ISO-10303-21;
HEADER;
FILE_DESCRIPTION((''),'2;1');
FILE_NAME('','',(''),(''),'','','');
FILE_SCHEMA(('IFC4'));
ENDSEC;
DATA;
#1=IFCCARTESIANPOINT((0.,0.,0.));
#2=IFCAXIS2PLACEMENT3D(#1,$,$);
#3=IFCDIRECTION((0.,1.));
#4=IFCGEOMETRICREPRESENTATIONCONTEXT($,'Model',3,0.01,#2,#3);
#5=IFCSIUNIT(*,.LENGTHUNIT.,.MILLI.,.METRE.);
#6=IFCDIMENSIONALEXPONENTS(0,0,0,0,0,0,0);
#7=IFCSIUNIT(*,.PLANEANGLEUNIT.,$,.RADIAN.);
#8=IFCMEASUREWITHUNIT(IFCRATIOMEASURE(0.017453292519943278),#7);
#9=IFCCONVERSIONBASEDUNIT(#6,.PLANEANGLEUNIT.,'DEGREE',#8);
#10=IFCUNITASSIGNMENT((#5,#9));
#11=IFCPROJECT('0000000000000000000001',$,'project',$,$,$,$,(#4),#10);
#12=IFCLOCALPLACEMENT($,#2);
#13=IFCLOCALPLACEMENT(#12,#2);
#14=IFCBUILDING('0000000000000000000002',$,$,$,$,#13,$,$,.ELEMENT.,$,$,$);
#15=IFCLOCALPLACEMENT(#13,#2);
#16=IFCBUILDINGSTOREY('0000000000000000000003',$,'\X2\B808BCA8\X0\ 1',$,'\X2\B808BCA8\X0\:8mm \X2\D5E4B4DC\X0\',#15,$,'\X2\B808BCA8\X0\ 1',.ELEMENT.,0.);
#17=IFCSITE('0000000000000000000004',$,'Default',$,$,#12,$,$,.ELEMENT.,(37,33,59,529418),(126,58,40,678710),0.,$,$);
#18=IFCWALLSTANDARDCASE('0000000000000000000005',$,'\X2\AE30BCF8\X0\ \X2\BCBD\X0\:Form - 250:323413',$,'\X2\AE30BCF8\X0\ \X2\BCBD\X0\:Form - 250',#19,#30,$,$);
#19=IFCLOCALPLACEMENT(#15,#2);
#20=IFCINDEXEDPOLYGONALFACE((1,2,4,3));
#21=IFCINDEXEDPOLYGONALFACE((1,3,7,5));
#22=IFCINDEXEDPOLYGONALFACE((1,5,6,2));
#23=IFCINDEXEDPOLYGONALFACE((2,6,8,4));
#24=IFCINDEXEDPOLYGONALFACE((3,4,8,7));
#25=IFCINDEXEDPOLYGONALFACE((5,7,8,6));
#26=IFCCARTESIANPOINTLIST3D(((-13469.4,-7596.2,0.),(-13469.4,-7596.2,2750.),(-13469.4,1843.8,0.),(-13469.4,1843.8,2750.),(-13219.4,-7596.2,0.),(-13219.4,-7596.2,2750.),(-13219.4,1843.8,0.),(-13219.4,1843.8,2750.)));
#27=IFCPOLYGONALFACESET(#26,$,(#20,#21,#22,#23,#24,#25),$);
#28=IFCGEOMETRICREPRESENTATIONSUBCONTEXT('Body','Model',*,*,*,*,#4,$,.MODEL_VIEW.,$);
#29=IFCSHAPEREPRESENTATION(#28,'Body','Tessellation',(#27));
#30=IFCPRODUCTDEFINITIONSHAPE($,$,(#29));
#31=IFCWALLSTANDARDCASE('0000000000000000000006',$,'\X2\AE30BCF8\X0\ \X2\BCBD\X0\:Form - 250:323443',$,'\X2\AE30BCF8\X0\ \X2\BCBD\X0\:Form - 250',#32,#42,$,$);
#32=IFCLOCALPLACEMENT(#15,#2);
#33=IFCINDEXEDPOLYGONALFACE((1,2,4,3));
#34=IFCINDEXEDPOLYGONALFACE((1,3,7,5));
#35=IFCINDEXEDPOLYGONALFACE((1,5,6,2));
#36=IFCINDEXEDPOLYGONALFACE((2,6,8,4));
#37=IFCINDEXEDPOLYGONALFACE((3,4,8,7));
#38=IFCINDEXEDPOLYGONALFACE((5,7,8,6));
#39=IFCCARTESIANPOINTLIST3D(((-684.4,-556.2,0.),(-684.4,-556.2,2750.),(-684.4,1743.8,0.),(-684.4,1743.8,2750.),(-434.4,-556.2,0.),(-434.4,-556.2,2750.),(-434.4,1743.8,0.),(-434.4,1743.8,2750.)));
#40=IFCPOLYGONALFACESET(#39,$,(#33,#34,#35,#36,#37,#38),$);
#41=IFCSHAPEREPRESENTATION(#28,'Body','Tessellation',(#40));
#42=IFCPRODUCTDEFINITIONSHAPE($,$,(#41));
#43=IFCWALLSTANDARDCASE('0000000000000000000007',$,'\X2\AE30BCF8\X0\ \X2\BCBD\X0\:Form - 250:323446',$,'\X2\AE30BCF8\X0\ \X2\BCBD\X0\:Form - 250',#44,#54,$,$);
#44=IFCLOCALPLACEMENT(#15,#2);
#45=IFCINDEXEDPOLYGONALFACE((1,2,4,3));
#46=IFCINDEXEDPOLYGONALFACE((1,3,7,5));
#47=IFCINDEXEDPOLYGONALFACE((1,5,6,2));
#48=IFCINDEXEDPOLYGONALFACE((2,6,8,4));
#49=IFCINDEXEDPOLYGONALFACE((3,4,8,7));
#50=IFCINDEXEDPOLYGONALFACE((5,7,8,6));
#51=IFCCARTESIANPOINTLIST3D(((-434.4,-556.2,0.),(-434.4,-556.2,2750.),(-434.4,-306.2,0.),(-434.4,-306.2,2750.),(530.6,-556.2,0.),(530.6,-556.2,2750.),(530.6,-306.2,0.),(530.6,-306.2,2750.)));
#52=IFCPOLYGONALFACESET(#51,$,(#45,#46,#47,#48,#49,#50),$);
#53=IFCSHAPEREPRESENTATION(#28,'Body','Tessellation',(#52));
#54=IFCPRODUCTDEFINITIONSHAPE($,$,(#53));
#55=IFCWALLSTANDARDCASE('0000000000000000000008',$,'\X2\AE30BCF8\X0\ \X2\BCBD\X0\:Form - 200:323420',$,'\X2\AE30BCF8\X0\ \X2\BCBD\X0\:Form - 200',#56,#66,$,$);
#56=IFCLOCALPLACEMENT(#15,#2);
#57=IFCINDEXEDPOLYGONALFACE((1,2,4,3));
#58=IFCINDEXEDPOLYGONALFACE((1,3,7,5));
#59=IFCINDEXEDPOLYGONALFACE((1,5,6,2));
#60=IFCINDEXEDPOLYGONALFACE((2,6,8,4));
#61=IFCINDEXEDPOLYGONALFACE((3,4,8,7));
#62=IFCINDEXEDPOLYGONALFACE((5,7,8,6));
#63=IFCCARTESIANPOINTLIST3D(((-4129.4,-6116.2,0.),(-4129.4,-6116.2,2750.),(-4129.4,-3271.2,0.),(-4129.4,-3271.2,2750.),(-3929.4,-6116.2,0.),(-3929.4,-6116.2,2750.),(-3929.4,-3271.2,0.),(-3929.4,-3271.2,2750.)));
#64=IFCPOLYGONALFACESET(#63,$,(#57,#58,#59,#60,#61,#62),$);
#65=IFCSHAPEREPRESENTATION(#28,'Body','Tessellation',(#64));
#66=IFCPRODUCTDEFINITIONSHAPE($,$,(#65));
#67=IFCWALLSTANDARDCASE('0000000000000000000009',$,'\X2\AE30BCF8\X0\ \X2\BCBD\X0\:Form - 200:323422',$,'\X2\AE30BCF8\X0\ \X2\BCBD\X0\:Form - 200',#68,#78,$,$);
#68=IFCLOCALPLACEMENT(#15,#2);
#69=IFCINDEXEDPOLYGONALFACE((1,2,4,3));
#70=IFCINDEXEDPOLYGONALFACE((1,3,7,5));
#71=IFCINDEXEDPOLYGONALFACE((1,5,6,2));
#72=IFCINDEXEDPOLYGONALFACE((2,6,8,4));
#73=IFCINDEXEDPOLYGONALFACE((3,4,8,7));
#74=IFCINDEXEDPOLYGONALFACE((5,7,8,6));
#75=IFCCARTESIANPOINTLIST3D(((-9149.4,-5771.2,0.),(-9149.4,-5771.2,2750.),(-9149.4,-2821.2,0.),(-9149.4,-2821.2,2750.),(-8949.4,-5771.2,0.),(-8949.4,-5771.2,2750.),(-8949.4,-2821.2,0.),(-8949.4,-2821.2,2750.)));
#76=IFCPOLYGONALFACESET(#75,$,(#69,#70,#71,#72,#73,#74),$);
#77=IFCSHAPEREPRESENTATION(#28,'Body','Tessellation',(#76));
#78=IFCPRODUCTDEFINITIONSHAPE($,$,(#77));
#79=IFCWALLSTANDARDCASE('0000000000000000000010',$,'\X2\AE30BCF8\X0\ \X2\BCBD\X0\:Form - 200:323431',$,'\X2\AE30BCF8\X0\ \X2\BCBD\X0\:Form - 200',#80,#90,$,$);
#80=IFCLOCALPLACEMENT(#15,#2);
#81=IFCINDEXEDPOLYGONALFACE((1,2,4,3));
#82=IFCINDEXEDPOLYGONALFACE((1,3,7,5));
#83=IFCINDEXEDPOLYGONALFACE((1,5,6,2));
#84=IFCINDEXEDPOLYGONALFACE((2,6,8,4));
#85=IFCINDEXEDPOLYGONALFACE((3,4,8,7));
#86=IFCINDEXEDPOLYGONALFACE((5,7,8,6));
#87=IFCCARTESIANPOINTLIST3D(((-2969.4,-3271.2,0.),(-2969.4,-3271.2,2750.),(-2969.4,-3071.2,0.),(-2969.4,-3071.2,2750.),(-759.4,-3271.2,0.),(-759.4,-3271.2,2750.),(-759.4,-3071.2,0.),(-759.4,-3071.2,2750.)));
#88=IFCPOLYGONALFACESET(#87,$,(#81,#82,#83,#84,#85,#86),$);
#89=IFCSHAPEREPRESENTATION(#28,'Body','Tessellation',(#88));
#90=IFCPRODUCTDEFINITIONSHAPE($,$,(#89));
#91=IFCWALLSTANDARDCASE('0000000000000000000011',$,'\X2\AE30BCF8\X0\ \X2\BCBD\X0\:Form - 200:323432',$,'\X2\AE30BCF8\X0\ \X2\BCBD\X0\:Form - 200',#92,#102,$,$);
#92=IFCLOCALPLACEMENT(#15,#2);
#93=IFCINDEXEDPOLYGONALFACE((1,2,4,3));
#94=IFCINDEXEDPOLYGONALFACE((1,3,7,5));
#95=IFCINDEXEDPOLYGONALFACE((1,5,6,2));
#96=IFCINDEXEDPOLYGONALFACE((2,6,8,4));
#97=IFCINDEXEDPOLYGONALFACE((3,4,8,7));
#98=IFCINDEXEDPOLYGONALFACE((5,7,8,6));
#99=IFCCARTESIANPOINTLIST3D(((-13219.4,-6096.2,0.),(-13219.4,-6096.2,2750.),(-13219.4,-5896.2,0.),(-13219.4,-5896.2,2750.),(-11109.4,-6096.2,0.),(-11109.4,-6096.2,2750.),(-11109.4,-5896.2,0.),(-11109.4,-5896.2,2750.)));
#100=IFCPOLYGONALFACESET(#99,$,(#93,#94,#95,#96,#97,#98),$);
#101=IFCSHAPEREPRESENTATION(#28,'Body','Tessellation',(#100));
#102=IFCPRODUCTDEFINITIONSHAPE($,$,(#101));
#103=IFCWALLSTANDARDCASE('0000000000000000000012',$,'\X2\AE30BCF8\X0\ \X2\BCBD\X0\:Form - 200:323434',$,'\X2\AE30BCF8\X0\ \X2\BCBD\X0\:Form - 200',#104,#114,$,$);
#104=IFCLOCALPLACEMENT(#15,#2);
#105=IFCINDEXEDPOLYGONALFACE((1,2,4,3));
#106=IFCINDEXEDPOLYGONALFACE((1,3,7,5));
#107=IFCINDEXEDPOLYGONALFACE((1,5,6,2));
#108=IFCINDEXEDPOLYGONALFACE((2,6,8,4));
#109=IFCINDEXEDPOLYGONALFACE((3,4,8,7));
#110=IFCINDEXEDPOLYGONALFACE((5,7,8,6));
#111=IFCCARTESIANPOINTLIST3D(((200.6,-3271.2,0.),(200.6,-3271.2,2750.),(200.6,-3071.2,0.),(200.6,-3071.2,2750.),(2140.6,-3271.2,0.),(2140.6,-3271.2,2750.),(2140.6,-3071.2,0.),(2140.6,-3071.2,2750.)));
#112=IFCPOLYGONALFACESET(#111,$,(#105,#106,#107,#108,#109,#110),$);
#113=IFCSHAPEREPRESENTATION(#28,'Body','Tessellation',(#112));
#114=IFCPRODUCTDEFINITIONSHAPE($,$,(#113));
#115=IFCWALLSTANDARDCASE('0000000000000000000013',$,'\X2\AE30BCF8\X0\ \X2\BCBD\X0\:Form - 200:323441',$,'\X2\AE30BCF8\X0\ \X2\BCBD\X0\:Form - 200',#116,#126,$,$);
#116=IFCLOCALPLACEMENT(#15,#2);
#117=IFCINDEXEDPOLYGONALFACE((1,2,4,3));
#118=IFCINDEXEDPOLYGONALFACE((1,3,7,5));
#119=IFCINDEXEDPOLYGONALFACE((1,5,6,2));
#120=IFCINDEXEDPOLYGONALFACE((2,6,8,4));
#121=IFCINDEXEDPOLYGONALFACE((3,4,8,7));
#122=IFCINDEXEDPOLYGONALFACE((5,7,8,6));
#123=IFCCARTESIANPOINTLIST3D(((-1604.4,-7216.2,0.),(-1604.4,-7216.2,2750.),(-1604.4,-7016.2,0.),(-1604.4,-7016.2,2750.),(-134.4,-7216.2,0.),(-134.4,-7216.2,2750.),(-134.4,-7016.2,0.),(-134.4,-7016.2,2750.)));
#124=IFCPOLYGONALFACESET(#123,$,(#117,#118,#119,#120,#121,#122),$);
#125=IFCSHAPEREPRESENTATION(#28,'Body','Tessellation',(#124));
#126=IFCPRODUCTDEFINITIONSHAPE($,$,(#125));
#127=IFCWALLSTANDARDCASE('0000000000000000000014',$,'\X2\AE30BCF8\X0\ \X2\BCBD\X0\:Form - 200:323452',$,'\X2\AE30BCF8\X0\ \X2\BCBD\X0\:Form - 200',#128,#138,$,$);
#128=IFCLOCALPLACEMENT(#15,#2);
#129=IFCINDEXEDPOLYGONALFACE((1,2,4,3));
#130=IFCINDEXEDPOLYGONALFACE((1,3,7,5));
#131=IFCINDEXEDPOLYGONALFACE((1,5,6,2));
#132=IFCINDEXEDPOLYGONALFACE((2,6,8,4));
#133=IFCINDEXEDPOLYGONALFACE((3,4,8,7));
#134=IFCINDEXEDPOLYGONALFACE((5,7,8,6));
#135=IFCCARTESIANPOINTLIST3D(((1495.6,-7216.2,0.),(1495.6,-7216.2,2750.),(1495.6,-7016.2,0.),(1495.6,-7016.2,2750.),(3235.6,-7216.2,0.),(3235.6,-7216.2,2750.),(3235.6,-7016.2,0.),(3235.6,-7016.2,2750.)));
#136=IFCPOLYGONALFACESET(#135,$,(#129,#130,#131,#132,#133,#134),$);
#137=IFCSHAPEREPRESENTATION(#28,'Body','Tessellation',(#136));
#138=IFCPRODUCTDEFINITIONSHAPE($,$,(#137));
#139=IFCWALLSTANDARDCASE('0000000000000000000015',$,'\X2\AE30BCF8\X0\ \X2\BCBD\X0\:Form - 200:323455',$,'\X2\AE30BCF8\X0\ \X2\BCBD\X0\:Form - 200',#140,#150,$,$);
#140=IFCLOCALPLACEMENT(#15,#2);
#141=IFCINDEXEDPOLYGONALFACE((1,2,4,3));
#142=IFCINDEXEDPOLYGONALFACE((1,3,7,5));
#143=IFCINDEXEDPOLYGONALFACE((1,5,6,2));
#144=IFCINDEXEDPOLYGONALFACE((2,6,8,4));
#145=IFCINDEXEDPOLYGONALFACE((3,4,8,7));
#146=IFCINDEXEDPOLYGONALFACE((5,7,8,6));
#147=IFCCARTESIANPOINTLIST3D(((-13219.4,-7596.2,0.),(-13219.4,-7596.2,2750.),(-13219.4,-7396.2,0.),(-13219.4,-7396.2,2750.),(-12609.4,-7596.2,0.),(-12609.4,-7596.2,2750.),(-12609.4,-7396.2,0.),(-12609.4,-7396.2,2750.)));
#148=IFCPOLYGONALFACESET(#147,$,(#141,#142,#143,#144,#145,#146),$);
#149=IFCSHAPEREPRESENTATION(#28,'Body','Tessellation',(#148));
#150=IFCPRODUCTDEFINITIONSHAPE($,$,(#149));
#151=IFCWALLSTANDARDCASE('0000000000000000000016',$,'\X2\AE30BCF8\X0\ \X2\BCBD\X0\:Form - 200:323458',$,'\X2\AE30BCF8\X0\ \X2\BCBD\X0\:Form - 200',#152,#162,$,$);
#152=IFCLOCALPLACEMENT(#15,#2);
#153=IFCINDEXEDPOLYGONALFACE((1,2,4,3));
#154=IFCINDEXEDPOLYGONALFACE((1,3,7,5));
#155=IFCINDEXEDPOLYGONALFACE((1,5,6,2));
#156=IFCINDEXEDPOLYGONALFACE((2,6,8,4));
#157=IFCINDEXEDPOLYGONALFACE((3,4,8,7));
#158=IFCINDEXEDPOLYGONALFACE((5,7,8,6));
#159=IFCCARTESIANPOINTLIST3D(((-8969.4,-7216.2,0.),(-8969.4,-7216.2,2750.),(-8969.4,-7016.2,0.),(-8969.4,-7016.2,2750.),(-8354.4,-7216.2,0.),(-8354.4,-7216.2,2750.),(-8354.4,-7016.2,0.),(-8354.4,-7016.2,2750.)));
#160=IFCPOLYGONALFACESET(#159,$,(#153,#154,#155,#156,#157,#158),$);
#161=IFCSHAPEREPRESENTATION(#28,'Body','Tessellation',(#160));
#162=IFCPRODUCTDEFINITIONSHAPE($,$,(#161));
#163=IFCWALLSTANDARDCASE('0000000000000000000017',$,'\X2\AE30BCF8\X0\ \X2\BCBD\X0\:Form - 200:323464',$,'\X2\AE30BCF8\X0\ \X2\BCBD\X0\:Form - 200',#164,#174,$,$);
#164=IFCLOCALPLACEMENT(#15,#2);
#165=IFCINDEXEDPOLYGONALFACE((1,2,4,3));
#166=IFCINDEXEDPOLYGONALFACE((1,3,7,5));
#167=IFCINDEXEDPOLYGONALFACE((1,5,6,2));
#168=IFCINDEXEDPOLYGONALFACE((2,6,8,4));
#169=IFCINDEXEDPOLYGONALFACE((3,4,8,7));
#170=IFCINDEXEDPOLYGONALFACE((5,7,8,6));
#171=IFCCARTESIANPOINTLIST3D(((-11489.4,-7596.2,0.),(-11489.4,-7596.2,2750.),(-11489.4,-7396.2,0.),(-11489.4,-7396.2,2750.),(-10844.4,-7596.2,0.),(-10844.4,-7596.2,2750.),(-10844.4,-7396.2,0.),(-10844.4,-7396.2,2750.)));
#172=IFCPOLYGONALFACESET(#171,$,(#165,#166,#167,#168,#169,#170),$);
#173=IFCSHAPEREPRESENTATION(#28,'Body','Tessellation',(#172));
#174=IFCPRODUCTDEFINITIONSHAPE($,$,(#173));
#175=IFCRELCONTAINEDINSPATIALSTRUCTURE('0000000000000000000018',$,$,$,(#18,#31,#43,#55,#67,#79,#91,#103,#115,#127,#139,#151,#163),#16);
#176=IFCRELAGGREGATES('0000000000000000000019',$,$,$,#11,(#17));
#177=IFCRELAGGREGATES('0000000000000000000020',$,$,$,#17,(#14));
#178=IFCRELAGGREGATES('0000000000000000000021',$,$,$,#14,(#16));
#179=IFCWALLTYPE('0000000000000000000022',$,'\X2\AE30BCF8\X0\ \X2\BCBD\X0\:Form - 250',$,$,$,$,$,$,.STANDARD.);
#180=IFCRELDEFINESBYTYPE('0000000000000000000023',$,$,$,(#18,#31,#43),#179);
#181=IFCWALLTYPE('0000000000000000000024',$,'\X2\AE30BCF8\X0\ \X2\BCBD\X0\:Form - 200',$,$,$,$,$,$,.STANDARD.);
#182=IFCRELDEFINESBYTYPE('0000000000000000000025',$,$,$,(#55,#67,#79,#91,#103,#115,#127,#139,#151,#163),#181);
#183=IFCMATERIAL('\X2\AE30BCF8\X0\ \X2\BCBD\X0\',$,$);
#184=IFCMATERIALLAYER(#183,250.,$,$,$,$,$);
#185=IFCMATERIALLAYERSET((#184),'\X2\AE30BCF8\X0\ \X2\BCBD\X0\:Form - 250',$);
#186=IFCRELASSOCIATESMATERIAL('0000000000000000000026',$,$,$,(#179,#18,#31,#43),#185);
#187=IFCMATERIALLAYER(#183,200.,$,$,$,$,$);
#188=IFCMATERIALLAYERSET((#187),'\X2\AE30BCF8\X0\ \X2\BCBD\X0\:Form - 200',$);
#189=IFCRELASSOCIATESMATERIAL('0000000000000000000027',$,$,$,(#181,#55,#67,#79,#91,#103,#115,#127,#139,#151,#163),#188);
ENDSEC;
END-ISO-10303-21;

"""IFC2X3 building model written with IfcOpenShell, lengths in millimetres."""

from ifc_helpers import new_model, entity, si_unit, converted_unit, direction, frame, frame_2d, origin, place, context, subcontext, project, spatial, rectangle, extrude, material, layer, layer_set, layer_usage, type_object, element, save


model = new_model("IFC2X3")

# Units and contexts
model_context = context("Model", 3, precision=0.01, world=origin(), true_north=direction((0.0, 1.0)))
body_context = subcontext(model_context, "Body", "Model", "MODEL_VIEW")
ifc_project = project(units=[si_unit("LENGTHUNIT", "METRE", prefix="MILLI"), converted_unit("PLANEANGLEUNIT", "DEGREE", entity("IfcRatioMeasure", 0.017453292519943278), si_unit("PLANEANGLEUNIT", "RADIAN"), dimensions=[0, 0, 0, 0, 0, 0, 0])], contexts=[model_context])

# Site, building, storey
site_placement = place(None, origin())
site = spatial("IfcSite", under=ifc_project, at=site_placement, Name="Default", CompositionType="ELEMENT", RefLatitude=(37, 33, 59, 529418), RefLongitude=(126, 58, 40, 678710), RefElevation=0.0)
building_placement = place(site_placement, origin())
building = spatial("IfcBuilding", under=site, at=building_placement, CompositionType="ELEMENT")
storey_placement = place(building_placement, origin())
storey = spatial("IfcBuildingStorey", under=building, at=storey_placement, Name="레벨 1", ObjectType="레벨:8mm 헤드", LongName="레벨 1", CompositionType="ELEMENT", Elevation=0.0)

# Walls
ifc_material_1 = material(Name="기본 벽")
ifc_layer_1 = layer(ifc_material_1, 250.0)
ifc_layer_set_1 = layer_set([ifc_layer_1], Name="기본 벽:Form - 250")
ifc_layer_usage_1 = layer_usage(ifc_layer_set_1, "AXIS2", "POSITIVE", -125.0)
wall_type_1 = type_object("IfcWallType", Name="기본 벽:Form - 250", PredefinedType="STANDARD", material=ifc_layer_set_1)
wall_1_placement = place(storey_placement, frame((-13344.4, -7596.2, 0.0), z_axis=(0.0, 0.0, 1.0), x_axis=(0.0, 1.0, 0.0)))
element("IfcWallStandardCase", 1, at=wall_1_placement, inside=storey, type_object=wall_type_1, material=ifc_layer_usage_1, Name="기본 벽:Form - 250:323413", ObjectType="기본 벽:Form - 250", context=body_context, shape_type="SweptSolid", body=[
    extrude(rectangle(XDim=9440.0, YDim=250.0, at=frame_2d((4720.0, 0.0), x_axis=(-1.0, 0.0))), origin(), (0.0, 0.0, 1.0), 2750.0),
])
ifc_layer_usage_2 = layer_usage(ifc_layer_set_1, "AXIS2", "POSITIVE", -125.0)
wall_2_placement = place(storey_placement, frame((-559.4, -556.2, 0.0), z_axis=(0.0, 0.0, 1.0), x_axis=(0.0, 1.0, 0.0)))
element("IfcWallStandardCase", 2, at=wall_2_placement, inside=storey, type_object=wall_type_1, material=ifc_layer_usage_2, Name="기본 벽:Form - 250:323443", ObjectType="기본 벽:Form - 250", context=body_context, shape_type="SweptSolid", body=[
    extrude(rectangle(XDim=2300.0, YDim=250.0, at=frame_2d((1150.0, 0.0), x_axis=(-1.0, 0.0))), origin(), (0.0, 0.0, 1.0), 2750.0),
])
ifc_layer_usage_3 = layer_usage(ifc_layer_set_1, "AXIS2", "POSITIVE", -125.0)
wall_3_placement = place(storey_placement, frame((530.6, -431.2, 0.0), z_axis=(0.0, 0.0, 1.0), x_axis=(-1.0, 0.0, 0.0)))
element("IfcWallStandardCase", 3, at=wall_3_placement, inside=storey, type_object=wall_type_1, material=ifc_layer_usage_3, Name="기본 벽:Form - 250:323446", ObjectType="기본 벽:Form - 250", context=body_context, shape_type="SweptSolid", body=[
    extrude(rectangle(XDim=965.0, YDim=250.0, at=frame_2d((482.5, 0.0), x_axis=(-1.0, 0.0))), origin(), (0.0, 0.0, 1.0), 2750.0),
])
ifc_layer_2 = layer(ifc_material_1, 200.0)
ifc_layer_set_2 = layer_set([ifc_layer_2], Name="기본 벽:Form - 200")
ifc_layer_usage_4 = layer_usage(ifc_layer_set_2, "AXIS2", "POSITIVE", -100.0)
wall_type_2 = type_object("IfcWallType", Name="기본 벽:Form - 200", PredefinedType="STANDARD", material=ifc_layer_set_2)
wall_4_placement = place(storey_placement, frame((-4029.4, -6116.2, 0.0), z_axis=(0.0, 0.0, 1.0), x_axis=(0.0, 1.0, 0.0)))
element("IfcWallStandardCase", 4, at=wall_4_placement, inside=storey, type_object=wall_type_2, material=ifc_layer_usage_4, Name="기본 벽:Form - 200:323420", ObjectType="기본 벽:Form - 200", context=body_context, shape_type="SweptSolid", body=[
    extrude(rectangle(XDim=2845.0, YDim=200.0, at=frame_2d((1422.5, 0.0), x_axis=(-1.0, 0.0))), origin(), (0.0, 0.0, 1.0), 2750.0),
])
ifc_layer_usage_5 = layer_usage(ifc_layer_set_2, "AXIS2", "POSITIVE", -100.0)
wall_5_placement = place(storey_placement, frame((-9049.4, -2821.2, 0.0), z_axis=(0.0, 0.0, 1.0), x_axis=(0.0, -1.0, 0.0)))
element("IfcWallStandardCase", 5, at=wall_5_placement, inside=storey, type_object=wall_type_2, material=ifc_layer_usage_5, Name="기본 벽:Form - 200:323422", ObjectType="기본 벽:Form - 200", context=body_context, shape_type="SweptSolid", body=[
    extrude(rectangle(XDim=2950.0, YDim=200.0, at=frame_2d((1475.0, 0.0), x_axis=(-1.0, 0.0))), origin(), (0.0, 0.0, 1.0), 2750.0),
])
ifc_layer_usage_6 = layer_usage(ifc_layer_set_2, "AXIS2", "POSITIVE", -100.0)
wall_6_placement = place(storey_placement, frame((-2969.4, -3171.2, 0.0)))
element("IfcWallStandardCase", 6, at=wall_6_placement, inside=storey, type_object=wall_type_2, material=ifc_layer_usage_6, Name="기본 벽:Form - 200:323431", ObjectType="기본 벽:Form - 200", context=body_context, shape_type="SweptSolid", body=[
    extrude(rectangle(XDim=2210.0, YDim=200.0, at=frame_2d((1105.0, 0.0), x_axis=(-1.0, 0.0))), origin(), (0.0, 0.0, 1.0), 2750.0),
])
ifc_layer_usage_7 = layer_usage(ifc_layer_set_2, "AXIS2", "POSITIVE", -100.0)
wall_7_placement = place(storey_placement, frame((-13219.4, -5996.2, 0.0)))
element("IfcWallStandardCase", 7, at=wall_7_placement, inside=storey, type_object=wall_type_2, material=ifc_layer_usage_7, Name="기본 벽:Form - 200:323432", ObjectType="기본 벽:Form - 200", context=body_context, shape_type="SweptSolid", body=[
    extrude(rectangle(XDim=2110.0, YDim=200.0, at=frame_2d((1055.0, 0.0), x_axis=(-1.0, 0.0))), origin(), (0.0, 0.0, 1.0), 2750.0),
])
ifc_layer_usage_8 = layer_usage(ifc_layer_set_2, "AXIS2", "POSITIVE", -100.0)
wall_8_placement = place(storey_placement, frame((2140.6, -3171.2, 0.0), z_axis=(0.0, 0.0, 1.0), x_axis=(-1.0, 0.0, 0.0)))
element("IfcWallStandardCase", 8, at=wall_8_placement, inside=storey, type_object=wall_type_2, material=ifc_layer_usage_8, Name="기본 벽:Form - 200:323434", ObjectType="기본 벽:Form - 200", context=body_context, shape_type="SweptSolid", body=[
    extrude(rectangle(XDim=1940.0, YDim=200.0, at=frame_2d((970.0, 0.0), x_axis=(-1.0, 0.0))), origin(), (0.0, 0.0, 1.0), 2750.0),
])
ifc_layer_usage_9 = layer_usage(ifc_layer_set_2, "AXIS2", "POSITIVE", -100.0)
wall_9_placement = place(storey_placement, frame((-1604.4, -7116.2, 0.0)))
element("IfcWallStandardCase", 9, at=wall_9_placement, inside=storey, type_object=wall_type_2, material=ifc_layer_usage_9, Name="기본 벽:Form - 200:323441", ObjectType="기본 벽:Form - 200", context=body_context, shape_type="SweptSolid", body=[
    extrude(rectangle(XDim=1470.0, YDim=200.0, at=frame_2d((735.0, 0.0), x_axis=(-1.0, 0.0))), origin(), (0.0, 0.0, 1.0), 2750.0),
])
ifc_layer_usage_10 = layer_usage(ifc_layer_set_2, "AXIS2", "POSITIVE", -100.0)
wall_10_placement = place(storey_placement, frame((1495.6, -7116.2, 0.0)))
element("IfcWallStandardCase", 10, at=wall_10_placement, inside=storey, type_object=wall_type_2, material=ifc_layer_usage_10, Name="기본 벽:Form - 200:323452", ObjectType="기본 벽:Form - 200", context=body_context, shape_type="SweptSolid", body=[
    extrude(rectangle(XDim=1740.0, YDim=200.0, at=frame_2d((870.0, 0.0), x_axis=(-1.0, 0.0))), origin(), (0.0, 0.0, 1.0), 2750.0),
])
ifc_layer_usage_11 = layer_usage(ifc_layer_set_2, "AXIS2", "NEGATIVE", 100.0)
wall_11_placement = place(storey_placement, frame((-12609.4, -7496.2, 0.0), z_axis=(0.0, 0.0, 1.0), x_axis=(-1.0, 0.0, 0.0)))
element("IfcWallStandardCase", 11, at=wall_11_placement, inside=storey, type_object=wall_type_2, material=ifc_layer_usage_11, Name="기본 벽:Form - 200:323455", ObjectType="기본 벽:Form - 200", context=body_context, shape_type="SweptSolid", body=[
    extrude(rectangle(XDim=610.0, YDim=200.0, at=frame_2d((305.0, 0.0), x_axis=(-1.0, 0.0))), origin(), (0.0, 0.0, 1.0), 2750.0),
])
ifc_layer_usage_12 = layer_usage(ifc_layer_set_2, "AXIS2", "POSITIVE", -100.0)
wall_12_placement = place(storey_placement, frame((-8354.4, -7116.2, 0.0), z_axis=(0.0, 0.0, 1.0), x_axis=(-1.0, 0.0, 0.0)))
element("IfcWallStandardCase", 12, at=wall_12_placement, inside=storey, type_object=wall_type_2, material=ifc_layer_usage_12, Name="기본 벽:Form - 200:323458", ObjectType="기본 벽:Form - 200", context=body_context, shape_type="SweptSolid", body=[
    extrude(rectangle(XDim=615.0, YDim=200.0, at=frame_2d((307.5, 0.0), x_axis=(-1.0, 0.0))), origin(), (0.0, 0.0, 1.0), 2750.0),
])
ifc_layer_usage_13 = layer_usage(ifc_layer_set_2, "AXIS2", "POSITIVE", -100.0)
wall_13_placement = place(storey_placement, frame((-10844.4, -7496.2, 0.0), z_axis=(0.0, 0.0, 1.0), x_axis=(-1.0, 0.0, 0.0)))
element("IfcWallStandardCase", 13, at=wall_13_placement, inside=storey, type_object=wall_type_2, material=ifc_layer_usage_13, Name="기본 벽:Form - 200:323464", ObjectType="기본 벽:Form - 200", context=body_context, shape_type="SweptSolid", body=[
    extrude(rectangle(XDim=645.0, YDim=200.0, at=frame_2d((322.5, 0.0), x_axis=(-1.0, 0.0))), origin(), (0.0, 0.0, 1.0), 2750.0),
])

save(model, "model.ifc")
